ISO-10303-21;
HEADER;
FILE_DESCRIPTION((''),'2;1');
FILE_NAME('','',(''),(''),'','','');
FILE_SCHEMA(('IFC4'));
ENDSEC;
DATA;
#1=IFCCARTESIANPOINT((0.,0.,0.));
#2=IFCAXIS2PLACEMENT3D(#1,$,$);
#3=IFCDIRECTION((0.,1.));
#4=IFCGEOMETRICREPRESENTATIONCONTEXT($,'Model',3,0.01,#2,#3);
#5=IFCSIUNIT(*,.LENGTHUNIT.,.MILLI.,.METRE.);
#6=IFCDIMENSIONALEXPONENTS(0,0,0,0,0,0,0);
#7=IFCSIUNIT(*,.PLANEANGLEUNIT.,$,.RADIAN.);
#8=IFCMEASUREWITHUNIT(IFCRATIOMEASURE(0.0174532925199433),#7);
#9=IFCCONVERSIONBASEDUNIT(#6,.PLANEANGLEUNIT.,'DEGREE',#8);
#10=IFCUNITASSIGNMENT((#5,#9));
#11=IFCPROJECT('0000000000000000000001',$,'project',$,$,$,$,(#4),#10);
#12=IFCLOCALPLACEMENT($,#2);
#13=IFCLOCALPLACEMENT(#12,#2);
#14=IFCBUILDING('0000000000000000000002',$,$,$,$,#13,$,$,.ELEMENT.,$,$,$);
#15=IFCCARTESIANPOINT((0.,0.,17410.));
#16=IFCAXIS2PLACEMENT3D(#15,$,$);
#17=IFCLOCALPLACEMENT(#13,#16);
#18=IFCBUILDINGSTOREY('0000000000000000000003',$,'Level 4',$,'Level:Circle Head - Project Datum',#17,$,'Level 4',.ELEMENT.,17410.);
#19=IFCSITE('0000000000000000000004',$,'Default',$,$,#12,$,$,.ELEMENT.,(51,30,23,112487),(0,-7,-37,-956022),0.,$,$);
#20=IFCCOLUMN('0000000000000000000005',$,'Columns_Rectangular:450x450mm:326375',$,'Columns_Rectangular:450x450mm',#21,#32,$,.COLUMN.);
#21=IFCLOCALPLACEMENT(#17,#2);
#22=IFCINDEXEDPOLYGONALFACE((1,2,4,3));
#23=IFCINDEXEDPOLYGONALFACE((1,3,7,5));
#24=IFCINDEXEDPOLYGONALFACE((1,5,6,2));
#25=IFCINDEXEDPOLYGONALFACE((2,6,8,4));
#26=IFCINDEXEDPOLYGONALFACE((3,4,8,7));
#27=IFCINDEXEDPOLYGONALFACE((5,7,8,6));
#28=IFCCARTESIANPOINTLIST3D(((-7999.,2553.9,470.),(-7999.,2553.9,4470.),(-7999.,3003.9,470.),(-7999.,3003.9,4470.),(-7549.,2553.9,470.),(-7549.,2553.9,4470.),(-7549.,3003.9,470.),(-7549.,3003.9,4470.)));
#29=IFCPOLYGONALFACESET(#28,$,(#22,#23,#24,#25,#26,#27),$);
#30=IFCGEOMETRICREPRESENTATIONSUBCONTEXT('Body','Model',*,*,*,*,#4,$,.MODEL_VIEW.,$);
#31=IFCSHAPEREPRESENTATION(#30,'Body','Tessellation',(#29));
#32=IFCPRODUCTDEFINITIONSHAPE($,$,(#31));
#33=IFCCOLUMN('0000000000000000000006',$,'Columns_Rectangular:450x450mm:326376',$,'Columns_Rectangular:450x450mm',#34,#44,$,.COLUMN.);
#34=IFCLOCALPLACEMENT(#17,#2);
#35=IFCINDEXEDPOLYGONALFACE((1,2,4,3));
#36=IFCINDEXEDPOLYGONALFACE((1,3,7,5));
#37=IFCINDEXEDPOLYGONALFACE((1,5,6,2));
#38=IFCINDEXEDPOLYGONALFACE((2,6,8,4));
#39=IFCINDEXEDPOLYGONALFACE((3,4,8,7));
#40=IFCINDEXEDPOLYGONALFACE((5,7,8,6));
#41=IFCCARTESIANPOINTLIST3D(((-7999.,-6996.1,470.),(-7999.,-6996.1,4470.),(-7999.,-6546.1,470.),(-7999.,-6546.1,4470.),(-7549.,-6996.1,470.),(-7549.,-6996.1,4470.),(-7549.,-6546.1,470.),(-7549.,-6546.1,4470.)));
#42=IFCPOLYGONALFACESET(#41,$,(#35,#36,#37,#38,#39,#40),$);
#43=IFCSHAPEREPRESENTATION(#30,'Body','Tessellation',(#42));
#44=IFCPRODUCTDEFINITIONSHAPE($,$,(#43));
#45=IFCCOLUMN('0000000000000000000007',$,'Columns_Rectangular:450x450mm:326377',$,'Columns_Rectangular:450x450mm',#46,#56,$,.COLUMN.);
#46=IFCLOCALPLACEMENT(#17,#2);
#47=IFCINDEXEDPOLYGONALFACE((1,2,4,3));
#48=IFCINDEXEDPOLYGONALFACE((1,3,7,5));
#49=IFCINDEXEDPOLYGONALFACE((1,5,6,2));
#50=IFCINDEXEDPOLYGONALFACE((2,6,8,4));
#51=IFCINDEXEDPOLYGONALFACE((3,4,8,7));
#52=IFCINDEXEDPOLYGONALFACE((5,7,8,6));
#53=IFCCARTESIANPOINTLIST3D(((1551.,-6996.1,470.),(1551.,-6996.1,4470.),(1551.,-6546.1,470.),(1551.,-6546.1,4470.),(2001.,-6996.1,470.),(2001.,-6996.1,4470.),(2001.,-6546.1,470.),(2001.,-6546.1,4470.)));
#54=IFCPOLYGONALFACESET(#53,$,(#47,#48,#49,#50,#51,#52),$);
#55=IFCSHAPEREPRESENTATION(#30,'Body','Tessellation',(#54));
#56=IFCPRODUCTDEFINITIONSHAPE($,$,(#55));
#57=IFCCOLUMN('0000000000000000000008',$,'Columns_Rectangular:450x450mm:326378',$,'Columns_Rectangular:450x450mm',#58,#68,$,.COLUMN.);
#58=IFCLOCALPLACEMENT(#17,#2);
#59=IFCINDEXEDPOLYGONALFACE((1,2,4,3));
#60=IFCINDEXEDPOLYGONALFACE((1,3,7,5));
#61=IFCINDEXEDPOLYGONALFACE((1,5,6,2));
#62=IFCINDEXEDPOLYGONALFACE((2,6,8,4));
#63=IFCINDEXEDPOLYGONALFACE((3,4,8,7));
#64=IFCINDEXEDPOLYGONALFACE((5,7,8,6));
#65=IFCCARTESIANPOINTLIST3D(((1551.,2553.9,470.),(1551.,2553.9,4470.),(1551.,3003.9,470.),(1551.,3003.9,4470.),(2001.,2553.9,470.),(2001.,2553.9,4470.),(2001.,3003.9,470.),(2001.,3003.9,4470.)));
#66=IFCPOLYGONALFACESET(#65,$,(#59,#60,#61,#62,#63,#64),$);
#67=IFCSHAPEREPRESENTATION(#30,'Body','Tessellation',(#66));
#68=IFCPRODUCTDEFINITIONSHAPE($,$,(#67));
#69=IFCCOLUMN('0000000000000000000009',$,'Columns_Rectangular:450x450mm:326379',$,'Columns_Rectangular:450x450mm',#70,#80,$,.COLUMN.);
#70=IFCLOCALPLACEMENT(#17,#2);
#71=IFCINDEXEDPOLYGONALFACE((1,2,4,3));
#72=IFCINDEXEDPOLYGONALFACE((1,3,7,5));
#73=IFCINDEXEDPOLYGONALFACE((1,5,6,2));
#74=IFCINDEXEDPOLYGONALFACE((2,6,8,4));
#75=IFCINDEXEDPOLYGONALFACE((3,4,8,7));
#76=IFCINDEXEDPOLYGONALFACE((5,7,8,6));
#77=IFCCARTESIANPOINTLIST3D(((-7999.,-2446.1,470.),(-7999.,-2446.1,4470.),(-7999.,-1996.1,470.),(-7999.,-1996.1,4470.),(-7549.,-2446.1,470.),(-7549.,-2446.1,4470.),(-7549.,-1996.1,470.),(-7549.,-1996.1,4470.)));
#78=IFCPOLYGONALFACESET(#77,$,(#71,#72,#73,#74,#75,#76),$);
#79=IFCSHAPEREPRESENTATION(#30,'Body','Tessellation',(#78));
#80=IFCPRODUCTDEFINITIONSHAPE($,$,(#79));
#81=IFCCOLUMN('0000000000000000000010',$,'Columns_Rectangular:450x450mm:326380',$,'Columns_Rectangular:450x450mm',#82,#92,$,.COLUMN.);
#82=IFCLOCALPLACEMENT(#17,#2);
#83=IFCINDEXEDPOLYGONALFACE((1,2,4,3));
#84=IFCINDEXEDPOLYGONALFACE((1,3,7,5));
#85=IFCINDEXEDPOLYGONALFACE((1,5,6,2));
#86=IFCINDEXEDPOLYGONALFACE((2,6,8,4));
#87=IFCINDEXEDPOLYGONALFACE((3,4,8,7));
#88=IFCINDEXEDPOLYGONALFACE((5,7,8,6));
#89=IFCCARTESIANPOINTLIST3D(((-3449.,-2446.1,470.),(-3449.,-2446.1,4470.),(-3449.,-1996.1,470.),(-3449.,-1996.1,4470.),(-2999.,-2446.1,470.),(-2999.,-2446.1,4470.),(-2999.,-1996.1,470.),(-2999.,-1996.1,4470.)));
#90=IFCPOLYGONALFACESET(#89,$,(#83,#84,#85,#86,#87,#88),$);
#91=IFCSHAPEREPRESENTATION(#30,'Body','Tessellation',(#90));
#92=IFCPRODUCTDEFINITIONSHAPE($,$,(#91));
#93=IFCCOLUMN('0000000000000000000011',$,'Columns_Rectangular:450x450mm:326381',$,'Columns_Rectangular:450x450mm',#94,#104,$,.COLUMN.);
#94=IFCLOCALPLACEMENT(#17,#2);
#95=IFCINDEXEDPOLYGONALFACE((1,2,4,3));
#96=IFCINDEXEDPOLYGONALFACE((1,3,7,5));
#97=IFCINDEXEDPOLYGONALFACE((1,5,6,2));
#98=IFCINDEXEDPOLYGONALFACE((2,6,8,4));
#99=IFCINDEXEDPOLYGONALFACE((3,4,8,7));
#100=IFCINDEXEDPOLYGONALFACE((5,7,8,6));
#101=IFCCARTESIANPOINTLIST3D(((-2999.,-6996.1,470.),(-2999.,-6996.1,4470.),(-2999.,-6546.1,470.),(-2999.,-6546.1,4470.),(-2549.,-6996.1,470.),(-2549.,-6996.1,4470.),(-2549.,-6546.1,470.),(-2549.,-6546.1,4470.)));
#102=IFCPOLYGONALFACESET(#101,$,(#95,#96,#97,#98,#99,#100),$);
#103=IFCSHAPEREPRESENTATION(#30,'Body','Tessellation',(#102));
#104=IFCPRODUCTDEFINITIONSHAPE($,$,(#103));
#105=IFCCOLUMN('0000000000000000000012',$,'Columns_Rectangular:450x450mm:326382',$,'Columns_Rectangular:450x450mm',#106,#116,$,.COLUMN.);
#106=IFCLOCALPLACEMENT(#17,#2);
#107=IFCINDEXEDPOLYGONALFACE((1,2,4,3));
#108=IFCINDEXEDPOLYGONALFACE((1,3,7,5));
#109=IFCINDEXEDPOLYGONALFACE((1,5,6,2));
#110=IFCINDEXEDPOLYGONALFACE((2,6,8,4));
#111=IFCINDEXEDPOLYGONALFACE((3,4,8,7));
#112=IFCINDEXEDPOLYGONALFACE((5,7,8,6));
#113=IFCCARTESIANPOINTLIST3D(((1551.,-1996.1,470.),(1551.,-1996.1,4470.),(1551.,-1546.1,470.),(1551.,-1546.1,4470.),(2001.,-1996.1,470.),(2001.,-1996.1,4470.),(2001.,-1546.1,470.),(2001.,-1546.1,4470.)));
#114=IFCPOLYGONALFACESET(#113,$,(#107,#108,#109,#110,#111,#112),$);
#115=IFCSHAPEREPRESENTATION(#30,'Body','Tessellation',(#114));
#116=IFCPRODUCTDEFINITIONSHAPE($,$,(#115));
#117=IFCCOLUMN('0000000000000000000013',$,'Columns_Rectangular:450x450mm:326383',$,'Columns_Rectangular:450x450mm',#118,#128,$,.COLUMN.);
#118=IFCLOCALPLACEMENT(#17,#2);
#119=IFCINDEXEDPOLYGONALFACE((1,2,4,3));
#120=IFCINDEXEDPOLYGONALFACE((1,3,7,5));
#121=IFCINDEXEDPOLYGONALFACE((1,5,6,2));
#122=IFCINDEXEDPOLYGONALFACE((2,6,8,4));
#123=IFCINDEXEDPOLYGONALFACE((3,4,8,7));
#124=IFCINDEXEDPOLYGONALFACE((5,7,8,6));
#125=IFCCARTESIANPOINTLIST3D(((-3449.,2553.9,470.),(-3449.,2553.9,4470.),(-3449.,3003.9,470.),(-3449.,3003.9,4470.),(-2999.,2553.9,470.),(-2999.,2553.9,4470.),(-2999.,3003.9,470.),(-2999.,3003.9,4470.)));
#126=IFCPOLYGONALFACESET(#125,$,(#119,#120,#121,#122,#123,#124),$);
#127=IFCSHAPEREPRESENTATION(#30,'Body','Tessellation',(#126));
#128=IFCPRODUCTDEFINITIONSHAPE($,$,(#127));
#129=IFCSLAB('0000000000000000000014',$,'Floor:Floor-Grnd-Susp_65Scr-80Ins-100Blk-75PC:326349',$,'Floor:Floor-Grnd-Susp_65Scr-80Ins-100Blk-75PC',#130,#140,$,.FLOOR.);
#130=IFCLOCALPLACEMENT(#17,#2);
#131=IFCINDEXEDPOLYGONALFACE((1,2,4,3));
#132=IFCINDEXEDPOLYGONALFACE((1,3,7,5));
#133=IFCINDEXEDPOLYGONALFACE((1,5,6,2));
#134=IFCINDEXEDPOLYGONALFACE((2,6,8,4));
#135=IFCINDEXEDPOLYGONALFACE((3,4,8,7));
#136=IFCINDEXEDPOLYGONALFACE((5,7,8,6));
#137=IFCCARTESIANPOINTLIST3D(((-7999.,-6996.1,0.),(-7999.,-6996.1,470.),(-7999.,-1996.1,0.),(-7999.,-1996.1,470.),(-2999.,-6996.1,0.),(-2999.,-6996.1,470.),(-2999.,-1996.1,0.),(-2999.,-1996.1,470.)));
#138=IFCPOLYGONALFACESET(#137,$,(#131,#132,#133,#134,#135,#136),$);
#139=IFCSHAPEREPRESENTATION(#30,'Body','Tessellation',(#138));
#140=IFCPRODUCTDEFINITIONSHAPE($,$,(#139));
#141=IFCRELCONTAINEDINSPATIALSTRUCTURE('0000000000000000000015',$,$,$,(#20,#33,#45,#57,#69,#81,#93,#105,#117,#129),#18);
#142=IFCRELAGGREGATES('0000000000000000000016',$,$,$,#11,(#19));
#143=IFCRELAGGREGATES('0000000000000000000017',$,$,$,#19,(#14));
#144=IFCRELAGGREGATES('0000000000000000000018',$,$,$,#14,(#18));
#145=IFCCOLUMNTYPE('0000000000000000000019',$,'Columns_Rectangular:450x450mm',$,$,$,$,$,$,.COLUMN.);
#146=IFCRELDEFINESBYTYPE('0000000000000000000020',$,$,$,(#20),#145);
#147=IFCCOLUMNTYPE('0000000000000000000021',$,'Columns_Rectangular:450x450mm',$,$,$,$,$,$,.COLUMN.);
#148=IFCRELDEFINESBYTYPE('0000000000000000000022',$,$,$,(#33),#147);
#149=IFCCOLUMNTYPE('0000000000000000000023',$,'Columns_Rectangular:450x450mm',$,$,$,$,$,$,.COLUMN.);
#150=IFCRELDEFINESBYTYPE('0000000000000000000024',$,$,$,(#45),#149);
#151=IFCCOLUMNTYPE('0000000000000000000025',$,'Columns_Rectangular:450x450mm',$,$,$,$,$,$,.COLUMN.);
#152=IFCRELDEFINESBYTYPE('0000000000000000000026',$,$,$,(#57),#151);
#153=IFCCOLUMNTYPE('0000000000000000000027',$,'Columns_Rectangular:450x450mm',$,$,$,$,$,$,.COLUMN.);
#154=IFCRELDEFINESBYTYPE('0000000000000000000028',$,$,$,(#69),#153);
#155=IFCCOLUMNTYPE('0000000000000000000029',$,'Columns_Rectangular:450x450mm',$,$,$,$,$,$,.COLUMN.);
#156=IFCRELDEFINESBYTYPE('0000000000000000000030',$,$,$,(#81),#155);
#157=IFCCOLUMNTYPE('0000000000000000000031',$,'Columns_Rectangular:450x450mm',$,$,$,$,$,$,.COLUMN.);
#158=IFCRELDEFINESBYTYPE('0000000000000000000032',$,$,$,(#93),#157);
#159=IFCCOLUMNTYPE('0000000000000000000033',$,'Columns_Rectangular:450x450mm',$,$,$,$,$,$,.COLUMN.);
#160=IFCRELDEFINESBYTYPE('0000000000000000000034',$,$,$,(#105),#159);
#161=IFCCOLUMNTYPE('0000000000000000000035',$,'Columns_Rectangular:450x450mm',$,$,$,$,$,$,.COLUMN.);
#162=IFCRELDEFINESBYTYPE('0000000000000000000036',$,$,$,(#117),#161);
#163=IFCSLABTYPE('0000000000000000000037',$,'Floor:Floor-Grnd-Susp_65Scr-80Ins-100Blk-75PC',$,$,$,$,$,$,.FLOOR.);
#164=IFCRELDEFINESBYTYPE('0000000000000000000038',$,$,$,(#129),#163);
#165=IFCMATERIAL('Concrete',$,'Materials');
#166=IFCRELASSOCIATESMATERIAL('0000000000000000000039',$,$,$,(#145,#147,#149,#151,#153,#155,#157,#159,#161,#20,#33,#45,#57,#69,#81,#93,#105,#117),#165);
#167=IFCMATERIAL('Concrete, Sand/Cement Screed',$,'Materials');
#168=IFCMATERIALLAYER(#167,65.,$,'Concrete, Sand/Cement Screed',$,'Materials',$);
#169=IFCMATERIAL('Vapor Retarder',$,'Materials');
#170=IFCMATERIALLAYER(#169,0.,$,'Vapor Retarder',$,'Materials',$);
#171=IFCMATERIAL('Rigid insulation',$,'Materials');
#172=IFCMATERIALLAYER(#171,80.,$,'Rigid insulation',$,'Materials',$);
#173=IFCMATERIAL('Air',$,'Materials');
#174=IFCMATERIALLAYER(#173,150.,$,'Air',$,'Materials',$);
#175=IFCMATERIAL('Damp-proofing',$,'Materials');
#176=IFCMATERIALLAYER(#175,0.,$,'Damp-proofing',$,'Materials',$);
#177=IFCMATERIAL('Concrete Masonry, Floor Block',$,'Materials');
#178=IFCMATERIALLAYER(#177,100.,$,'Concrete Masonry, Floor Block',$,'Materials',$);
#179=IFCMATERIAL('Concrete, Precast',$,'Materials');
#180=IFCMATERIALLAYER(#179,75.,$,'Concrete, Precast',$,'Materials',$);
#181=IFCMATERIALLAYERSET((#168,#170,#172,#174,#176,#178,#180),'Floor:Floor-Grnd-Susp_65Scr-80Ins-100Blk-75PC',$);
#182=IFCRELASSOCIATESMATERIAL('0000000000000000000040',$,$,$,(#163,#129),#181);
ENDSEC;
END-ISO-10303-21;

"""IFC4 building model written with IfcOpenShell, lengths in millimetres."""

from ifc_helpers import new_model, entity, si_unit, converted_unit, direction, frame, frame_2d, origin, origin_2d_with_axis, place, context, subcontext, project, spatial, polyline, segment, composite_curve, rectangle, outline, extrude, source, transform, mapped, material, layer, layer_set, layer_usage, material_profile, profile_set, profile_usage, type_object, type_shapes, element, save


model = new_model("IFC4")

# Units and contexts
model_context = context("Model", 3, precision=0.01, world=origin(), true_north=direction((0.0, 1.0)))
body_context = subcontext(model_context, "Body", "Model", "MODEL_VIEW")
ifc_project = project(units=[si_unit("LENGTHUNIT", "METRE", prefix="MILLI"), converted_unit("PLANEANGLEUNIT", "DEGREE", entity("IfcRatioMeasure", 0.0174532925199433), si_unit("PLANEANGLEUNIT", "RADIAN"), dimensions=[0, 0, 0, 0, 0, 0, 0])], contexts=[model_context])

# Site, building, storey
site_placement = place(None, origin())
site = spatial("IfcSite", under=ifc_project, at=site_placement, Name="Default", CompositionType="ELEMENT", RefLatitude=(51, 30, 23, 112487), RefLongitude=(0, -7, -37, -956022), RefElevation=0.0)
building_placement = place(site_placement, origin())
building = spatial("IfcBuilding", under=site, at=building_placement, CompositionType="ELEMENT")
storey_placement = place(building_placement, frame((0.0, 0.0, 17410.0)))
storey = spatial("IfcBuildingStorey", under=building, at=storey_placement, Name="Level 4", ObjectType="Level:Circle Head - Project Datum", LongName="Level 4", CompositionType="ELEMENT", Elevation=17410.0)

# Columns
ifc_material_1 = material(Name="Concrete", Category="Materials")
ifc_material_profile = material_profile(ifc_material_1, outline(composite_curve([segment(polyline([(225.0, 225.0, 0.0), (225.0, -225.0, 0.0)]), True, "CONTINUOUS"), segment(polyline([(225.0, -225.0, 0.0), (-225.0, -225.0, 0.0)]), True, "CONTINUOUS"), segment(polyline([(-225.0, -225.0, 0.0), (-225.0, 225.0, 0.0)]), True, "CONTINUOUS"), segment(polyline([(-225.0, 225.0, 0.0), (225.0, 225.0, 0.0)]), True, "CONTINUOUS")], self_intersect=False), kind="CURVE"), Name="450x450mm")
ifc_profile_set = profile_set([ifc_material_profile], Name="450x450mm")
ifc_profile_usage_1 = profile_usage(ifc_profile_set)
column_type_1 = type_object("IfcColumnType", Name="Columns_Rectangular:450x450mm", PredefinedType="COLUMN", material=ifc_profile_set)
shared_shape_1 = source(origin(), body_context, "Body", "SweptSolid", [
    extrude(rectangle(XDim=450.0, YDim=450.0, at=frame_2d((0.0, 0.0), x_axis=(1.0, 0.0))), frame((-7774.0, 2778.9, 17880.0), z_axis=(0.0, 0.0, 1.0), x_axis=(0.0, -1.0, 0.0)), (0.0, 0.0, 1.0), 4000.0),
])
type_shapes(column_type_1, [shared_shape_1])
column_1_placement = place(storey_placement, frame((0.0, 0.0, -17410.0)))
element("IfcColumn", 1, at=column_1_placement, inside=storey, type_object=column_type_1, material=ifc_profile_usage_1, Name="Columns_Rectangular:450x450mm:326375", ObjectType="Columns_Rectangular:450x450mm", PredefinedType="COLUMN", context=body_context, shape_type="MappedRepresentation", body=[
    mapped(shared_shape_1, transform((0.0, 0.0, 0.0), scale=1.0)),
])
ifc_profile_usage_2 = profile_usage(ifc_profile_set)
column_type_2 = type_object("IfcColumnType", Name="Columns_Rectangular:450x450mm", PredefinedType="COLUMN", material=ifc_profile_set)
shared_shape_2 = source(origin(), body_context, "Body", "SweptSolid", [
    extrude(rectangle(XDim=450.0, YDim=450.0, at=frame_2d((0.0, 0.0), x_axis=(1.0, 0.0))), frame((-7774.0, -6771.1, 17880.0), z_axis=(0.0, 0.0, 1.0), x_axis=(0.0, -1.0, 0.0)), (0.0, 0.0, 1.0), 4000.0),
])
type_shapes(column_type_2, [shared_shape_2])
column_2_placement = place(storey_placement, frame((0.0, 0.0, -17410.0)))
element("IfcColumn", 2, at=column_2_placement, inside=storey, type_object=column_type_2, material=ifc_profile_usage_2, Name="Columns_Rectangular:450x450mm:326376", ObjectType="Columns_Rectangular:450x450mm", PredefinedType="COLUMN", context=body_context, shape_type="MappedRepresentation", body=[
    mapped(shared_shape_2, transform((0.0, 0.0, 0.0), scale=1.0)),
])
ifc_profile_usage_3 = profile_usage(ifc_profile_set)
column_type_3 = type_object("IfcColumnType", Name="Columns_Rectangular:450x450mm", PredefinedType="COLUMN", material=ifc_profile_set)
shared_shape_3 = source(origin(), body_context, "Body", "SweptSolid", [
    extrude(rectangle(XDim=450.0, YDim=450.0, at=frame_2d((0.0, 0.0), x_axis=(1.0, 0.0))), frame((1776.0, -6771.1, 17880.0), z_axis=(0.0, 0.0, 1.0), x_axis=(0.0, -1.0, 0.0)), (0.0, 0.0, 1.0), 4000.0),
])
type_shapes(column_type_3, [shared_shape_3])
column_3_placement = place(storey_placement, frame((0.0, 0.0, -17410.0)))
element("IfcColumn", 3, at=column_3_placement, inside=storey, type_object=column_type_3, material=ifc_profile_usage_3, Name="Columns_Rectangular:450x450mm:326377", ObjectType="Columns_Rectangular:450x450mm", PredefinedType="COLUMN", context=body_context, shape_type="MappedRepresentation", body=[
    mapped(shared_shape_3, transform((0.0, 0.0, 0.0), scale=1.0)),
])
ifc_profile_usage_4 = profile_usage(ifc_profile_set)
column_type_4 = type_object("IfcColumnType", Name="Columns_Rectangular:450x450mm", PredefinedType="COLUMN", material=ifc_profile_set)
shared_shape_4 = source(origin(), body_context, "Body", "SweptSolid", [
    extrude(rectangle(XDim=450.0, YDim=450.0, at=frame_2d((0.0, 0.0), x_axis=(1.0, 0.0))), frame((1776.0, 2778.9, 17880.0), z_axis=(0.0, 0.0, 1.0), x_axis=(0.0, -1.0, 0.0)), (0.0, 0.0, 1.0), 4000.0),
])
type_shapes(column_type_4, [shared_shape_4])
column_4_placement = place(storey_placement, frame((0.0, 0.0, -17410.0)))
element("IfcColumn", 4, at=column_4_placement, inside=storey, type_object=column_type_4, material=ifc_profile_usage_4, Name="Columns_Rectangular:450x450mm:326378", ObjectType="Columns_Rectangular:450x450mm", PredefinedType="COLUMN", context=body_context, shape_type="MappedRepresentation", body=[
    mapped(shared_shape_4, transform((0.0, 0.0, 0.0), scale=1.0)),
])
ifc_profile_usage_5 = profile_usage(ifc_profile_set)
column_type_5 = type_object("IfcColumnType", Name="Columns_Rectangular:450x450mm", PredefinedType="COLUMN", material=ifc_profile_set)
shared_shape_5 = source(origin(), body_context, "Body", "SweptSolid", [
    extrude(rectangle(XDim=450.0, YDim=450.0, at=frame_2d((0.0, 0.0), x_axis=(1.0, 0.0))), frame((-7774.0, -2221.1, 17880.0), z_axis=(0.0, 0.0, 1.0), x_axis=(0.0, -1.0, 0.0)), (0.0, 0.0, 1.0), 4000.0),
])
type_shapes(column_type_5, [shared_shape_5])
column_5_placement = place(storey_placement, frame((0.0, 0.0, -17410.0)))
element("IfcColumn", 5, at=column_5_placement, inside=storey, type_object=column_type_5, material=ifc_profile_usage_5, Name="Columns_Rectangular:450x450mm:326379", ObjectType="Columns_Rectangular:450x450mm", PredefinedType="COLUMN", context=body_context, shape_type="MappedRepresentation", body=[
    mapped(shared_shape_5, transform((0.0, 0.0, 0.0), scale=1.0)),
])
ifc_profile_usage_6 = profile_usage(ifc_profile_set)
column_type_6 = type_object("IfcColumnType", Name="Columns_Rectangular:450x450mm", PredefinedType="COLUMN", material=ifc_profile_set)
shared_shape_6 = source(origin(), body_context, "Body", "SweptSolid", [
    extrude(rectangle(XDim=450.0, YDim=450.0, at=origin_2d_with_axis()), frame((0.0, 0.0, 17880.0), z_axis=(0.0, 0.0, 1.0), x_axis=(0.0, -1.0, 0.0)), (0.0, 0.0, 1.0), 4000.0),
])
type_shapes(column_type_6, [shared_shape_6])
column_6_placement = place(storey_placement, frame((-3224.0, -2221.1, -17410.0)))
element("IfcColumn", 6, at=column_6_placement, inside=storey, type_object=column_type_6, material=ifc_profile_usage_6, Name="Columns_Rectangular:450x450mm:326380", ObjectType="Columns_Rectangular:450x450mm", PredefinedType="COLUMN", context=body_context, shape_type="MappedRepresentation", body=[
    mapped(shared_shape_6, transform((0.0, 0.0, 0.0), scale=1.0)),
])
ifc_profile_usage_7 = profile_usage(ifc_profile_set)
column_type_7 = type_object("IfcColumnType", Name="Columns_Rectangular:450x450mm", PredefinedType="COLUMN", material=ifc_profile_set)
shared_shape_7 = source(origin(), body_context, "Body", "SweptSolid", [
    extrude(rectangle(XDim=450.0, YDim=450.0, at=frame_2d((0.0, 0.0), x_axis=(1.0, 0.0))), frame((-2774.0, -6771.1, 17880.0), z_axis=(0.0, 0.0, 1.0), x_axis=(0.0, -1.0, 0.0)), (0.0, 0.0, 1.0), 4000.0),
])
type_shapes(column_type_7, [shared_shape_7])
column_7_placement = place(storey_placement, frame((0.0, 0.0, -17410.0)))
element("IfcColumn", 7, at=column_7_placement, inside=storey, type_object=column_type_7, material=ifc_profile_usage_7, Name="Columns_Rectangular:450x450mm:326381", ObjectType="Columns_Rectangular:450x450mm", PredefinedType="COLUMN", context=body_context, shape_type="MappedRepresentation", body=[
    mapped(shared_shape_7, transform((0.0, 0.0, 0.0), scale=1.0)),
])
ifc_profile_usage_8 = profile_usage(ifc_profile_set)
column_type_8 = type_object("IfcColumnType", Name="Columns_Rectangular:450x450mm", PredefinedType="COLUMN", material=ifc_profile_set)
shared_shape_8 = source(origin(), body_context, "Body", "SweptSolid", [
    extrude(rectangle(XDim=450.0, YDim=450.0, at=frame_2d((0.0, 0.0), x_axis=(1.0, 0.0))), frame((1776.0, -1771.1, 17880.0), z_axis=(0.0, 0.0, 1.0), x_axis=(0.0, -1.0, 0.0)), (0.0, 0.0, 1.0), 4000.0),
])
type_shapes(column_type_8, [shared_shape_8])
column_8_placement = place(storey_placement, frame((0.0, 0.0, -17410.0)))
element("IfcColumn", 8, at=column_8_placement, inside=storey, type_object=column_type_8, material=ifc_profile_usage_8, Name="Columns_Rectangular:450x450mm:326382", ObjectType="Columns_Rectangular:450x450mm", PredefinedType="COLUMN", context=body_context, shape_type="MappedRepresentation", body=[
    mapped(shared_shape_8, transform((0.0, 0.0, 0.0), scale=1.0)),
])
ifc_profile_usage_9 = profile_usage(ifc_profile_set)
column_type_9 = type_object("IfcColumnType", Name="Columns_Rectangular:450x450mm", PredefinedType="COLUMN", material=ifc_profile_set)
shared_shape_9 = source(origin(), body_context, "Body", "SweptSolid", [
    extrude(rectangle(XDim=450.0, YDim=450.0, at=frame_2d((0.0, 0.0), x_axis=(1.0, 0.0))), frame((-3224.0, 2778.9, 17880.0), z_axis=(0.0, 0.0, 1.0), x_axis=(0.0, -1.0, 0.0)), (0.0, 0.0, 1.0), 4000.0),
])
type_shapes(column_type_9, [shared_shape_9])
column_9_placement = place(storey_placement, frame((0.0, 0.0, -17410.0)))
element("IfcColumn", 9, at=column_9_placement, inside=storey, type_object=column_type_9, material=ifc_profile_usage_9, Name="Columns_Rectangular:450x450mm:326383", ObjectType="Columns_Rectangular:450x450mm", PredefinedType="COLUMN", context=body_context, shape_type="MappedRepresentation", body=[
    mapped(shared_shape_9, transform((0.0, 0.0, 0.0), scale=1.0)),
])

# Slab
ifc_material_2 = material(Name="Concrete, Sand/Cement Screed", Category="Materials")
ifc_layer_1 = layer(ifc_material_2, 65.0, Name="Concrete, Sand/Cement Screed", Category="Materials")
ifc_material_3 = material(Name="Vapor Retarder", Category="Materials")
ifc_layer_2 = layer(ifc_material_3, 0.0, Name="Vapor Retarder", Category="Materials")
ifc_material_4 = material(Name="Rigid insulation", Category="Materials")
ifc_layer_3 = layer(ifc_material_4, 80.0, Name="Rigid insulation", Category="Materials")
ifc_material_5 = material(Name="Air", Category="Materials")
ifc_layer_4 = layer(ifc_material_5, 150.0, Name="Air", Category="Materials")
ifc_material_6 = material(Name="Damp-proofing", Category="Materials")
ifc_layer_5 = layer(ifc_material_6, 0.0, Name="Damp-proofing", Category="Materials")
ifc_material_7 = material(Name="Concrete Masonry, Floor Block", Category="Materials")
ifc_layer_6 = layer(ifc_material_7, 100.0, Name="Concrete Masonry, Floor Block", Category="Materials")
ifc_material_8 = material(Name="Concrete, Precast", Category="Materials")
ifc_layer_7 = layer(ifc_material_8, 75.0, Name="Concrete, Precast", Category="Materials")
ifc_layer_set_1 = layer_set([ifc_layer_1, ifc_layer_2, ifc_layer_3, ifc_layer_4, ifc_layer_5, ifc_layer_6, ifc_layer_7], Name="Floor:Floor-Grnd-Susp_65Scr-80Ins-100Blk-75PC")
ifc_layer_usage_1 = layer_usage(ifc_layer_set_1, "AXIS3", "POSITIVE", 0.0)
slab_type_1 = type_object("IfcSlabType", Name="Floor:Floor-Grnd-Susp_65Scr-80Ins-100Blk-75PC", PredefinedType="FLOOR", material=ifc_layer_set_1)
slab_1_placement = place(storey_placement, origin())
element("IfcSlab", 10, at=slab_1_placement, inside=storey, type_object=slab_type_1, material=ifc_layer_usage_1, Name="Floor:Floor-Grnd-Susp_65Scr-80Ins-100Blk-75PC:326349", ObjectType="Floor:Floor-Grnd-Susp_65Scr-80Ins-100Blk-75PC", PredefinedType="FLOOR", context=body_context, shape_type="SweptSolid", body=[
    extrude(rectangle(XDim=5000.0, YDim=5000.0, at=frame_2d((0.0, 0.0), x_axis=(1.0, 0.0))), frame((-5499.0, -4496.1, 470.0), z_axis=(0.0, 0.0, -1.0), x_axis=(0.0, 1.0, 0.0)), (0.0, 0.0, 1.0), 470.0),
])

save(model, "model.ifc")
